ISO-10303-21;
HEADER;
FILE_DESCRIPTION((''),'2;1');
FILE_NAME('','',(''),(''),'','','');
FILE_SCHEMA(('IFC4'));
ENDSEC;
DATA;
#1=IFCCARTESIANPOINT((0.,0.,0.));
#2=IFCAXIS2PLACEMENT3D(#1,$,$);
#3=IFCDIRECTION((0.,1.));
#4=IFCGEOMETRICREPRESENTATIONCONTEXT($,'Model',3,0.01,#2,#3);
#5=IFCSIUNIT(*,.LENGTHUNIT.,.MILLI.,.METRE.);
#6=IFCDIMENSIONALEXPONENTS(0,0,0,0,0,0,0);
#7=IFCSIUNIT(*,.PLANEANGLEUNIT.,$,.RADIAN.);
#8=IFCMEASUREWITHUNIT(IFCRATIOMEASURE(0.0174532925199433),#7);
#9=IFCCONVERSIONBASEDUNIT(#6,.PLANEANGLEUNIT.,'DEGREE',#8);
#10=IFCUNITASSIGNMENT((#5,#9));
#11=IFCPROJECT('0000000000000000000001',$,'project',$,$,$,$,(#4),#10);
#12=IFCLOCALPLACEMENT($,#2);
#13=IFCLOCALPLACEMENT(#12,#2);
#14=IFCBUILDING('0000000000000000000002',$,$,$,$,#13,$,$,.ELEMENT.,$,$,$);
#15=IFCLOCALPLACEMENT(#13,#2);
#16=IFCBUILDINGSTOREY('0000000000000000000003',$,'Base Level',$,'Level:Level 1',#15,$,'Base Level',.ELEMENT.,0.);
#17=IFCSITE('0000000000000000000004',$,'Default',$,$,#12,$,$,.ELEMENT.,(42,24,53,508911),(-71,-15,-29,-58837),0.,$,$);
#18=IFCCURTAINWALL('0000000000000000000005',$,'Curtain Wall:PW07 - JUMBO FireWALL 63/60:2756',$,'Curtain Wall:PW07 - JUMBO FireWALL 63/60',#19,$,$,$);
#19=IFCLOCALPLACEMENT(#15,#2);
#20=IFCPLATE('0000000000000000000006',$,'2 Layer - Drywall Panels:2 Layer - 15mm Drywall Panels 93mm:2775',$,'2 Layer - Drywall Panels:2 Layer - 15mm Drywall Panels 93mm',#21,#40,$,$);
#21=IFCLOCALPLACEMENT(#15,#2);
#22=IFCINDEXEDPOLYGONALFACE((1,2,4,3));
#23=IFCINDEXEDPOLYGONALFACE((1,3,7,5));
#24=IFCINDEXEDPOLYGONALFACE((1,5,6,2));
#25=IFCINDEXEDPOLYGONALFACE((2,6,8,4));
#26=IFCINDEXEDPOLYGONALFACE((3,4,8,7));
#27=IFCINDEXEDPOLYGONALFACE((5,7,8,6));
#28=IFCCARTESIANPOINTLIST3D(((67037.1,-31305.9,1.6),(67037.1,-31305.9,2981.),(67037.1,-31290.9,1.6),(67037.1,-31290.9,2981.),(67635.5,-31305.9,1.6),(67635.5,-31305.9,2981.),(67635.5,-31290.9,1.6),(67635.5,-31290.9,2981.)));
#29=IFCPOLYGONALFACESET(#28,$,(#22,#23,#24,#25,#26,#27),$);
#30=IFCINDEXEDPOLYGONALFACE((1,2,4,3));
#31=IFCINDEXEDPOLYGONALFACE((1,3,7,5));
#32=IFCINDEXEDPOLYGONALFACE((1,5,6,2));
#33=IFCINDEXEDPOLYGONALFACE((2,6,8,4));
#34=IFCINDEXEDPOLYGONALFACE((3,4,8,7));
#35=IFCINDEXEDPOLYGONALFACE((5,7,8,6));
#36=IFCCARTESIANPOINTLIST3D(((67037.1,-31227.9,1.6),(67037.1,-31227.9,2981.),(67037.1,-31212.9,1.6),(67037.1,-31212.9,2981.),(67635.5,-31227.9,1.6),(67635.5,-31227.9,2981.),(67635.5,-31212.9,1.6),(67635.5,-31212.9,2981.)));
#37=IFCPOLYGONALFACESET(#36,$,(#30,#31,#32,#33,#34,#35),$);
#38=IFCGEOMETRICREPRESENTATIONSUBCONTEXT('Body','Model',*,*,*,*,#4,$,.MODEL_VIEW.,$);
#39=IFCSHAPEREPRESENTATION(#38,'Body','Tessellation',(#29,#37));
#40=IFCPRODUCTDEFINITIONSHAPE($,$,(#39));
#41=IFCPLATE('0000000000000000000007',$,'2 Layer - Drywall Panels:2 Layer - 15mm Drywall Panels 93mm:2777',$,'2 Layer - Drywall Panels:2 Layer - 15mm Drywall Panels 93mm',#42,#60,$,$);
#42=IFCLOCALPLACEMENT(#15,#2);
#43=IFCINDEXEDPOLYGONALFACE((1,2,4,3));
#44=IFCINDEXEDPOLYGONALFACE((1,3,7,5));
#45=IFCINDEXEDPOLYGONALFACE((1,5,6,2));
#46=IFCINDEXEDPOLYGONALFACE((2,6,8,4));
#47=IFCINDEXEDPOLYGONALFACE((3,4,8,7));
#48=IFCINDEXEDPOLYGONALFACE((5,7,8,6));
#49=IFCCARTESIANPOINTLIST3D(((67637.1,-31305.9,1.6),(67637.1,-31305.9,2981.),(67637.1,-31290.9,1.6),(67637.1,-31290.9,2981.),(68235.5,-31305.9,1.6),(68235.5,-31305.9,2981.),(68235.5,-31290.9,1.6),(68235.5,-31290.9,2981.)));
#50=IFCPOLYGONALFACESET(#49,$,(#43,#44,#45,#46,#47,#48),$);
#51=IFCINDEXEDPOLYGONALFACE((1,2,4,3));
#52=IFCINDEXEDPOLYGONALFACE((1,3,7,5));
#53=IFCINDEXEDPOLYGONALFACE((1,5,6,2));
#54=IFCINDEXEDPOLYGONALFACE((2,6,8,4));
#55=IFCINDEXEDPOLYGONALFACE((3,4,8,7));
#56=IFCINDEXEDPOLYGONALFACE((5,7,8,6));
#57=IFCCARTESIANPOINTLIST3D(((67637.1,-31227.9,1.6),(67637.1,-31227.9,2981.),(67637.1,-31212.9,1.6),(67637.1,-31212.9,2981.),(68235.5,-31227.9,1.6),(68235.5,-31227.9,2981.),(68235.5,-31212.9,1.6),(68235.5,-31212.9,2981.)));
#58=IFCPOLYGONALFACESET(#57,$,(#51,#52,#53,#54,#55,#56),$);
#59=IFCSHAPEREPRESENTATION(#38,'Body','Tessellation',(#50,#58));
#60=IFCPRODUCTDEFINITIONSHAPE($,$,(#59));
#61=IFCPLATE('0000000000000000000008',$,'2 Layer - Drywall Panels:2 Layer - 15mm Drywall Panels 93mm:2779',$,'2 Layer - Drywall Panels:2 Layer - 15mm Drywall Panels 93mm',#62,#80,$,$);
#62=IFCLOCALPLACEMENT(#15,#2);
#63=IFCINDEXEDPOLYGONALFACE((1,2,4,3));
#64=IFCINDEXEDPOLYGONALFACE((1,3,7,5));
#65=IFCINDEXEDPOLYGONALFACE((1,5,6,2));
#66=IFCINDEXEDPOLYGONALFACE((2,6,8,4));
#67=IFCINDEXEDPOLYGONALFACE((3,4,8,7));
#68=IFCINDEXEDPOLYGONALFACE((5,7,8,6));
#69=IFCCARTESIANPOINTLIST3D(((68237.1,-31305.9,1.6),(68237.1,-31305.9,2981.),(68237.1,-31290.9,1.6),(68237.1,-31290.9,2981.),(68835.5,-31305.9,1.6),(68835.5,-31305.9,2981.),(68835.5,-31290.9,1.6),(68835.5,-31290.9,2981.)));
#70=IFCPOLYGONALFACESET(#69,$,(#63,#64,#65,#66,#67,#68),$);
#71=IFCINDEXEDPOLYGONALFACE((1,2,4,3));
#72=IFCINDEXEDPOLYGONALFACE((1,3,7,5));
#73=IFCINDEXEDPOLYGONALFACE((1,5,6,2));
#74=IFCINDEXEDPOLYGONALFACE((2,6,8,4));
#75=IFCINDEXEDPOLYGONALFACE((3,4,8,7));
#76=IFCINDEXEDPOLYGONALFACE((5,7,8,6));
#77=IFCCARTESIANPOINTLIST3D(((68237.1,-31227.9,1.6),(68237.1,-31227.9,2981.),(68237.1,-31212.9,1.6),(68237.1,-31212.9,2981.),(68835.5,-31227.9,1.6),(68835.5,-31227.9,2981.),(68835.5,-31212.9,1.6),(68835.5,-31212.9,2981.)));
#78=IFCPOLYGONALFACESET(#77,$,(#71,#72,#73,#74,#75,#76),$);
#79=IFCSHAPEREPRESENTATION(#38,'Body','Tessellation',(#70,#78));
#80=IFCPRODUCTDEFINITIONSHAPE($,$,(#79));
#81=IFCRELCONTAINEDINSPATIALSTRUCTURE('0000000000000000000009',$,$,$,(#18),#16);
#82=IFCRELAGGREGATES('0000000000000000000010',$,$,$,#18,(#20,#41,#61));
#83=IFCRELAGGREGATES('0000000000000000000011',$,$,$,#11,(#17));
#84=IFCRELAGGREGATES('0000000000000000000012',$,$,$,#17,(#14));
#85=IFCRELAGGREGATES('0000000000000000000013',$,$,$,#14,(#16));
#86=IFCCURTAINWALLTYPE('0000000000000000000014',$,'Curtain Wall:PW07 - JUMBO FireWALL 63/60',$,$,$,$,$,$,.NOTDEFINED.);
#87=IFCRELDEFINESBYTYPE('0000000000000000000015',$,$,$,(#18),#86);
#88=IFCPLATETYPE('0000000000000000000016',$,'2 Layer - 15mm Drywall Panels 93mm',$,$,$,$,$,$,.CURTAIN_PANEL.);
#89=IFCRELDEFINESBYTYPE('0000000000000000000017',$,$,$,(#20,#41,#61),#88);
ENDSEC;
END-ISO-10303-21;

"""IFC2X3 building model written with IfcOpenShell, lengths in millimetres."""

from ifc_helpers import new_model, entity, si_unit, converted_unit, direction, frame, frame_2d, origin, place, context, subcontext, project, spatial, rectangle, extrude, source, transform, mapped, type_object, type_shapes, element, aggregate, save


model = new_model("IFC2X3")

# Units and contexts
model_context = context("Model", 3, precision=0.01, world=origin(), true_north=direction((0.0, 1.0)))
body_context = subcontext(model_context, "Body", "Model", "MODEL_VIEW")
ifc_project = project(units=[si_unit("LENGTHUNIT", "METRE", prefix="MILLI"), converted_unit("PLANEANGLEUNIT", "DEGREE", entity("IfcRatioMeasure", 0.0174532925199433), si_unit("PLANEANGLEUNIT", "RADIAN"), dimensions=[0, 0, 0, 0, 0, 0, 0])], contexts=[model_context])

# Site, building, storey
site_placement = place(None, origin())
site = spatial("IfcSite", under=ifc_project, at=site_placement, Name="Default", CompositionType="ELEMENT", RefLatitude=(42, 24, 53, 508911), RefLongitude=(-71, -15, -29, -58837), RefElevation=0.0)
building_placement = place(site_placement, origin())
building = spatial("IfcBuilding", under=site, at=building_placement, CompositionType="ELEMENT")
storey_placement = place(building_placement, origin())
storey = spatial("IfcBuildingStorey", under=building, at=storey_placement, Name="Base Level", ObjectType="Level:Level 1", LongName="Base Level", CompositionType="ELEMENT", Elevation=0.0)

# Curtain wall, plates
curtain_wall_type = type_object("IfcCurtainWallType", Name="Curtain Wall:PW07 - JUMBO FireWALL 63/60", PredefinedType="NOTDEFINED")
curtain_wall_placement = place(building_placement, origin())
curtain_wall = element("IfcCurtainWall", 1, at=curtain_wall_placement, inside=storey, type_object=curtain_wall_type, Name="Curtain Wall:PW07 - JUMBO FireWALL 63/60:2756", ObjectType="Curtain Wall:PW07 - JUMBO FireWALL 63/60")
plate_type = type_object("IfcPlateType", Name="2 Layer - 15mm Drywall Panels 93mm", PredefinedType="CURTAIN_PANEL")
shared_shape_1 = source(origin(), body_context, "Body", "SweptSolid", [
    extrude(rectangle(XDim=598.4, YDim=15.0, at=frame_2d((0.0, 0.0), x_axis=(1.0, 0.0))), frame((0.0, -39.0, 0.0), z_axis=(0.0, 0.0, 1.0), x_axis=(-1.0, 0.0, 0.0)), (0.0, 0.0, 1.0), 2979.4),
    extrude(rectangle(XDim=15.0, YDim=598.4, at=frame_2d((0.0, 0.0), x_axis=(1.0, 0.0))), frame((0.0, 39.0, 0.0), z_axis=(0.0, 0.0, 1.0), x_axis=(0.0, 1.0, 0.0)), (0.0, 0.0, 1.0), 2979.4),
])
type_shapes(plate_type, [shared_shape_1])
plate_1_placement = place(curtain_wall_placement, frame((67336.3, -31259.4, 1.6)))
plate_1 = element("IfcPlate", 2, at=plate_1_placement, type_object=plate_type, Name="2 Layer - Drywall Panels:2 Layer - 15mm Drywall Panels 93mm:2775", ObjectType="2 Layer - Drywall Panels:2 Layer - 15mm Drywall Panels 93mm", context=body_context, shape_type="MappedRepresentation", body=[
    mapped(shared_shape_1, transform((0.0, 0.0, 0.0), scale=1.0)),
])
plate_2_placement = place(curtain_wall_placement, frame((67936.3, -31259.4, 1.6)))
plate_2 = element("IfcPlate", 3, at=plate_2_placement, type_object=plate_type, Name="2 Layer - Drywall Panels:2 Layer - 15mm Drywall Panels 93mm:2777", ObjectType="2 Layer - Drywall Panels:2 Layer - 15mm Drywall Panels 93mm", context=body_context, shape_type="MappedRepresentation", body=[
    mapped(shared_shape_1, transform((0.0, 0.0, 0.0), scale=1.0)),
])
plate_3_placement = place(curtain_wall_placement, frame((68536.3, -31259.4, 1.6)))
plate_3 = element("IfcPlate", 4, at=plate_3_placement, type_object=plate_type, Name="2 Layer - Drywall Panels:2 Layer - 15mm Drywall Panels 93mm:2779", ObjectType="2 Layer - Drywall Panels:2 Layer - 15mm Drywall Panels 93mm", context=body_context, shape_type="MappedRepresentation", body=[
    mapped(shared_shape_1, transform((0.0, 0.0, 0.0), scale=1.0)),
])
aggregate(curtain_wall, [plate_1, plate_2, plate_3])

save(model, "model.ifc")
